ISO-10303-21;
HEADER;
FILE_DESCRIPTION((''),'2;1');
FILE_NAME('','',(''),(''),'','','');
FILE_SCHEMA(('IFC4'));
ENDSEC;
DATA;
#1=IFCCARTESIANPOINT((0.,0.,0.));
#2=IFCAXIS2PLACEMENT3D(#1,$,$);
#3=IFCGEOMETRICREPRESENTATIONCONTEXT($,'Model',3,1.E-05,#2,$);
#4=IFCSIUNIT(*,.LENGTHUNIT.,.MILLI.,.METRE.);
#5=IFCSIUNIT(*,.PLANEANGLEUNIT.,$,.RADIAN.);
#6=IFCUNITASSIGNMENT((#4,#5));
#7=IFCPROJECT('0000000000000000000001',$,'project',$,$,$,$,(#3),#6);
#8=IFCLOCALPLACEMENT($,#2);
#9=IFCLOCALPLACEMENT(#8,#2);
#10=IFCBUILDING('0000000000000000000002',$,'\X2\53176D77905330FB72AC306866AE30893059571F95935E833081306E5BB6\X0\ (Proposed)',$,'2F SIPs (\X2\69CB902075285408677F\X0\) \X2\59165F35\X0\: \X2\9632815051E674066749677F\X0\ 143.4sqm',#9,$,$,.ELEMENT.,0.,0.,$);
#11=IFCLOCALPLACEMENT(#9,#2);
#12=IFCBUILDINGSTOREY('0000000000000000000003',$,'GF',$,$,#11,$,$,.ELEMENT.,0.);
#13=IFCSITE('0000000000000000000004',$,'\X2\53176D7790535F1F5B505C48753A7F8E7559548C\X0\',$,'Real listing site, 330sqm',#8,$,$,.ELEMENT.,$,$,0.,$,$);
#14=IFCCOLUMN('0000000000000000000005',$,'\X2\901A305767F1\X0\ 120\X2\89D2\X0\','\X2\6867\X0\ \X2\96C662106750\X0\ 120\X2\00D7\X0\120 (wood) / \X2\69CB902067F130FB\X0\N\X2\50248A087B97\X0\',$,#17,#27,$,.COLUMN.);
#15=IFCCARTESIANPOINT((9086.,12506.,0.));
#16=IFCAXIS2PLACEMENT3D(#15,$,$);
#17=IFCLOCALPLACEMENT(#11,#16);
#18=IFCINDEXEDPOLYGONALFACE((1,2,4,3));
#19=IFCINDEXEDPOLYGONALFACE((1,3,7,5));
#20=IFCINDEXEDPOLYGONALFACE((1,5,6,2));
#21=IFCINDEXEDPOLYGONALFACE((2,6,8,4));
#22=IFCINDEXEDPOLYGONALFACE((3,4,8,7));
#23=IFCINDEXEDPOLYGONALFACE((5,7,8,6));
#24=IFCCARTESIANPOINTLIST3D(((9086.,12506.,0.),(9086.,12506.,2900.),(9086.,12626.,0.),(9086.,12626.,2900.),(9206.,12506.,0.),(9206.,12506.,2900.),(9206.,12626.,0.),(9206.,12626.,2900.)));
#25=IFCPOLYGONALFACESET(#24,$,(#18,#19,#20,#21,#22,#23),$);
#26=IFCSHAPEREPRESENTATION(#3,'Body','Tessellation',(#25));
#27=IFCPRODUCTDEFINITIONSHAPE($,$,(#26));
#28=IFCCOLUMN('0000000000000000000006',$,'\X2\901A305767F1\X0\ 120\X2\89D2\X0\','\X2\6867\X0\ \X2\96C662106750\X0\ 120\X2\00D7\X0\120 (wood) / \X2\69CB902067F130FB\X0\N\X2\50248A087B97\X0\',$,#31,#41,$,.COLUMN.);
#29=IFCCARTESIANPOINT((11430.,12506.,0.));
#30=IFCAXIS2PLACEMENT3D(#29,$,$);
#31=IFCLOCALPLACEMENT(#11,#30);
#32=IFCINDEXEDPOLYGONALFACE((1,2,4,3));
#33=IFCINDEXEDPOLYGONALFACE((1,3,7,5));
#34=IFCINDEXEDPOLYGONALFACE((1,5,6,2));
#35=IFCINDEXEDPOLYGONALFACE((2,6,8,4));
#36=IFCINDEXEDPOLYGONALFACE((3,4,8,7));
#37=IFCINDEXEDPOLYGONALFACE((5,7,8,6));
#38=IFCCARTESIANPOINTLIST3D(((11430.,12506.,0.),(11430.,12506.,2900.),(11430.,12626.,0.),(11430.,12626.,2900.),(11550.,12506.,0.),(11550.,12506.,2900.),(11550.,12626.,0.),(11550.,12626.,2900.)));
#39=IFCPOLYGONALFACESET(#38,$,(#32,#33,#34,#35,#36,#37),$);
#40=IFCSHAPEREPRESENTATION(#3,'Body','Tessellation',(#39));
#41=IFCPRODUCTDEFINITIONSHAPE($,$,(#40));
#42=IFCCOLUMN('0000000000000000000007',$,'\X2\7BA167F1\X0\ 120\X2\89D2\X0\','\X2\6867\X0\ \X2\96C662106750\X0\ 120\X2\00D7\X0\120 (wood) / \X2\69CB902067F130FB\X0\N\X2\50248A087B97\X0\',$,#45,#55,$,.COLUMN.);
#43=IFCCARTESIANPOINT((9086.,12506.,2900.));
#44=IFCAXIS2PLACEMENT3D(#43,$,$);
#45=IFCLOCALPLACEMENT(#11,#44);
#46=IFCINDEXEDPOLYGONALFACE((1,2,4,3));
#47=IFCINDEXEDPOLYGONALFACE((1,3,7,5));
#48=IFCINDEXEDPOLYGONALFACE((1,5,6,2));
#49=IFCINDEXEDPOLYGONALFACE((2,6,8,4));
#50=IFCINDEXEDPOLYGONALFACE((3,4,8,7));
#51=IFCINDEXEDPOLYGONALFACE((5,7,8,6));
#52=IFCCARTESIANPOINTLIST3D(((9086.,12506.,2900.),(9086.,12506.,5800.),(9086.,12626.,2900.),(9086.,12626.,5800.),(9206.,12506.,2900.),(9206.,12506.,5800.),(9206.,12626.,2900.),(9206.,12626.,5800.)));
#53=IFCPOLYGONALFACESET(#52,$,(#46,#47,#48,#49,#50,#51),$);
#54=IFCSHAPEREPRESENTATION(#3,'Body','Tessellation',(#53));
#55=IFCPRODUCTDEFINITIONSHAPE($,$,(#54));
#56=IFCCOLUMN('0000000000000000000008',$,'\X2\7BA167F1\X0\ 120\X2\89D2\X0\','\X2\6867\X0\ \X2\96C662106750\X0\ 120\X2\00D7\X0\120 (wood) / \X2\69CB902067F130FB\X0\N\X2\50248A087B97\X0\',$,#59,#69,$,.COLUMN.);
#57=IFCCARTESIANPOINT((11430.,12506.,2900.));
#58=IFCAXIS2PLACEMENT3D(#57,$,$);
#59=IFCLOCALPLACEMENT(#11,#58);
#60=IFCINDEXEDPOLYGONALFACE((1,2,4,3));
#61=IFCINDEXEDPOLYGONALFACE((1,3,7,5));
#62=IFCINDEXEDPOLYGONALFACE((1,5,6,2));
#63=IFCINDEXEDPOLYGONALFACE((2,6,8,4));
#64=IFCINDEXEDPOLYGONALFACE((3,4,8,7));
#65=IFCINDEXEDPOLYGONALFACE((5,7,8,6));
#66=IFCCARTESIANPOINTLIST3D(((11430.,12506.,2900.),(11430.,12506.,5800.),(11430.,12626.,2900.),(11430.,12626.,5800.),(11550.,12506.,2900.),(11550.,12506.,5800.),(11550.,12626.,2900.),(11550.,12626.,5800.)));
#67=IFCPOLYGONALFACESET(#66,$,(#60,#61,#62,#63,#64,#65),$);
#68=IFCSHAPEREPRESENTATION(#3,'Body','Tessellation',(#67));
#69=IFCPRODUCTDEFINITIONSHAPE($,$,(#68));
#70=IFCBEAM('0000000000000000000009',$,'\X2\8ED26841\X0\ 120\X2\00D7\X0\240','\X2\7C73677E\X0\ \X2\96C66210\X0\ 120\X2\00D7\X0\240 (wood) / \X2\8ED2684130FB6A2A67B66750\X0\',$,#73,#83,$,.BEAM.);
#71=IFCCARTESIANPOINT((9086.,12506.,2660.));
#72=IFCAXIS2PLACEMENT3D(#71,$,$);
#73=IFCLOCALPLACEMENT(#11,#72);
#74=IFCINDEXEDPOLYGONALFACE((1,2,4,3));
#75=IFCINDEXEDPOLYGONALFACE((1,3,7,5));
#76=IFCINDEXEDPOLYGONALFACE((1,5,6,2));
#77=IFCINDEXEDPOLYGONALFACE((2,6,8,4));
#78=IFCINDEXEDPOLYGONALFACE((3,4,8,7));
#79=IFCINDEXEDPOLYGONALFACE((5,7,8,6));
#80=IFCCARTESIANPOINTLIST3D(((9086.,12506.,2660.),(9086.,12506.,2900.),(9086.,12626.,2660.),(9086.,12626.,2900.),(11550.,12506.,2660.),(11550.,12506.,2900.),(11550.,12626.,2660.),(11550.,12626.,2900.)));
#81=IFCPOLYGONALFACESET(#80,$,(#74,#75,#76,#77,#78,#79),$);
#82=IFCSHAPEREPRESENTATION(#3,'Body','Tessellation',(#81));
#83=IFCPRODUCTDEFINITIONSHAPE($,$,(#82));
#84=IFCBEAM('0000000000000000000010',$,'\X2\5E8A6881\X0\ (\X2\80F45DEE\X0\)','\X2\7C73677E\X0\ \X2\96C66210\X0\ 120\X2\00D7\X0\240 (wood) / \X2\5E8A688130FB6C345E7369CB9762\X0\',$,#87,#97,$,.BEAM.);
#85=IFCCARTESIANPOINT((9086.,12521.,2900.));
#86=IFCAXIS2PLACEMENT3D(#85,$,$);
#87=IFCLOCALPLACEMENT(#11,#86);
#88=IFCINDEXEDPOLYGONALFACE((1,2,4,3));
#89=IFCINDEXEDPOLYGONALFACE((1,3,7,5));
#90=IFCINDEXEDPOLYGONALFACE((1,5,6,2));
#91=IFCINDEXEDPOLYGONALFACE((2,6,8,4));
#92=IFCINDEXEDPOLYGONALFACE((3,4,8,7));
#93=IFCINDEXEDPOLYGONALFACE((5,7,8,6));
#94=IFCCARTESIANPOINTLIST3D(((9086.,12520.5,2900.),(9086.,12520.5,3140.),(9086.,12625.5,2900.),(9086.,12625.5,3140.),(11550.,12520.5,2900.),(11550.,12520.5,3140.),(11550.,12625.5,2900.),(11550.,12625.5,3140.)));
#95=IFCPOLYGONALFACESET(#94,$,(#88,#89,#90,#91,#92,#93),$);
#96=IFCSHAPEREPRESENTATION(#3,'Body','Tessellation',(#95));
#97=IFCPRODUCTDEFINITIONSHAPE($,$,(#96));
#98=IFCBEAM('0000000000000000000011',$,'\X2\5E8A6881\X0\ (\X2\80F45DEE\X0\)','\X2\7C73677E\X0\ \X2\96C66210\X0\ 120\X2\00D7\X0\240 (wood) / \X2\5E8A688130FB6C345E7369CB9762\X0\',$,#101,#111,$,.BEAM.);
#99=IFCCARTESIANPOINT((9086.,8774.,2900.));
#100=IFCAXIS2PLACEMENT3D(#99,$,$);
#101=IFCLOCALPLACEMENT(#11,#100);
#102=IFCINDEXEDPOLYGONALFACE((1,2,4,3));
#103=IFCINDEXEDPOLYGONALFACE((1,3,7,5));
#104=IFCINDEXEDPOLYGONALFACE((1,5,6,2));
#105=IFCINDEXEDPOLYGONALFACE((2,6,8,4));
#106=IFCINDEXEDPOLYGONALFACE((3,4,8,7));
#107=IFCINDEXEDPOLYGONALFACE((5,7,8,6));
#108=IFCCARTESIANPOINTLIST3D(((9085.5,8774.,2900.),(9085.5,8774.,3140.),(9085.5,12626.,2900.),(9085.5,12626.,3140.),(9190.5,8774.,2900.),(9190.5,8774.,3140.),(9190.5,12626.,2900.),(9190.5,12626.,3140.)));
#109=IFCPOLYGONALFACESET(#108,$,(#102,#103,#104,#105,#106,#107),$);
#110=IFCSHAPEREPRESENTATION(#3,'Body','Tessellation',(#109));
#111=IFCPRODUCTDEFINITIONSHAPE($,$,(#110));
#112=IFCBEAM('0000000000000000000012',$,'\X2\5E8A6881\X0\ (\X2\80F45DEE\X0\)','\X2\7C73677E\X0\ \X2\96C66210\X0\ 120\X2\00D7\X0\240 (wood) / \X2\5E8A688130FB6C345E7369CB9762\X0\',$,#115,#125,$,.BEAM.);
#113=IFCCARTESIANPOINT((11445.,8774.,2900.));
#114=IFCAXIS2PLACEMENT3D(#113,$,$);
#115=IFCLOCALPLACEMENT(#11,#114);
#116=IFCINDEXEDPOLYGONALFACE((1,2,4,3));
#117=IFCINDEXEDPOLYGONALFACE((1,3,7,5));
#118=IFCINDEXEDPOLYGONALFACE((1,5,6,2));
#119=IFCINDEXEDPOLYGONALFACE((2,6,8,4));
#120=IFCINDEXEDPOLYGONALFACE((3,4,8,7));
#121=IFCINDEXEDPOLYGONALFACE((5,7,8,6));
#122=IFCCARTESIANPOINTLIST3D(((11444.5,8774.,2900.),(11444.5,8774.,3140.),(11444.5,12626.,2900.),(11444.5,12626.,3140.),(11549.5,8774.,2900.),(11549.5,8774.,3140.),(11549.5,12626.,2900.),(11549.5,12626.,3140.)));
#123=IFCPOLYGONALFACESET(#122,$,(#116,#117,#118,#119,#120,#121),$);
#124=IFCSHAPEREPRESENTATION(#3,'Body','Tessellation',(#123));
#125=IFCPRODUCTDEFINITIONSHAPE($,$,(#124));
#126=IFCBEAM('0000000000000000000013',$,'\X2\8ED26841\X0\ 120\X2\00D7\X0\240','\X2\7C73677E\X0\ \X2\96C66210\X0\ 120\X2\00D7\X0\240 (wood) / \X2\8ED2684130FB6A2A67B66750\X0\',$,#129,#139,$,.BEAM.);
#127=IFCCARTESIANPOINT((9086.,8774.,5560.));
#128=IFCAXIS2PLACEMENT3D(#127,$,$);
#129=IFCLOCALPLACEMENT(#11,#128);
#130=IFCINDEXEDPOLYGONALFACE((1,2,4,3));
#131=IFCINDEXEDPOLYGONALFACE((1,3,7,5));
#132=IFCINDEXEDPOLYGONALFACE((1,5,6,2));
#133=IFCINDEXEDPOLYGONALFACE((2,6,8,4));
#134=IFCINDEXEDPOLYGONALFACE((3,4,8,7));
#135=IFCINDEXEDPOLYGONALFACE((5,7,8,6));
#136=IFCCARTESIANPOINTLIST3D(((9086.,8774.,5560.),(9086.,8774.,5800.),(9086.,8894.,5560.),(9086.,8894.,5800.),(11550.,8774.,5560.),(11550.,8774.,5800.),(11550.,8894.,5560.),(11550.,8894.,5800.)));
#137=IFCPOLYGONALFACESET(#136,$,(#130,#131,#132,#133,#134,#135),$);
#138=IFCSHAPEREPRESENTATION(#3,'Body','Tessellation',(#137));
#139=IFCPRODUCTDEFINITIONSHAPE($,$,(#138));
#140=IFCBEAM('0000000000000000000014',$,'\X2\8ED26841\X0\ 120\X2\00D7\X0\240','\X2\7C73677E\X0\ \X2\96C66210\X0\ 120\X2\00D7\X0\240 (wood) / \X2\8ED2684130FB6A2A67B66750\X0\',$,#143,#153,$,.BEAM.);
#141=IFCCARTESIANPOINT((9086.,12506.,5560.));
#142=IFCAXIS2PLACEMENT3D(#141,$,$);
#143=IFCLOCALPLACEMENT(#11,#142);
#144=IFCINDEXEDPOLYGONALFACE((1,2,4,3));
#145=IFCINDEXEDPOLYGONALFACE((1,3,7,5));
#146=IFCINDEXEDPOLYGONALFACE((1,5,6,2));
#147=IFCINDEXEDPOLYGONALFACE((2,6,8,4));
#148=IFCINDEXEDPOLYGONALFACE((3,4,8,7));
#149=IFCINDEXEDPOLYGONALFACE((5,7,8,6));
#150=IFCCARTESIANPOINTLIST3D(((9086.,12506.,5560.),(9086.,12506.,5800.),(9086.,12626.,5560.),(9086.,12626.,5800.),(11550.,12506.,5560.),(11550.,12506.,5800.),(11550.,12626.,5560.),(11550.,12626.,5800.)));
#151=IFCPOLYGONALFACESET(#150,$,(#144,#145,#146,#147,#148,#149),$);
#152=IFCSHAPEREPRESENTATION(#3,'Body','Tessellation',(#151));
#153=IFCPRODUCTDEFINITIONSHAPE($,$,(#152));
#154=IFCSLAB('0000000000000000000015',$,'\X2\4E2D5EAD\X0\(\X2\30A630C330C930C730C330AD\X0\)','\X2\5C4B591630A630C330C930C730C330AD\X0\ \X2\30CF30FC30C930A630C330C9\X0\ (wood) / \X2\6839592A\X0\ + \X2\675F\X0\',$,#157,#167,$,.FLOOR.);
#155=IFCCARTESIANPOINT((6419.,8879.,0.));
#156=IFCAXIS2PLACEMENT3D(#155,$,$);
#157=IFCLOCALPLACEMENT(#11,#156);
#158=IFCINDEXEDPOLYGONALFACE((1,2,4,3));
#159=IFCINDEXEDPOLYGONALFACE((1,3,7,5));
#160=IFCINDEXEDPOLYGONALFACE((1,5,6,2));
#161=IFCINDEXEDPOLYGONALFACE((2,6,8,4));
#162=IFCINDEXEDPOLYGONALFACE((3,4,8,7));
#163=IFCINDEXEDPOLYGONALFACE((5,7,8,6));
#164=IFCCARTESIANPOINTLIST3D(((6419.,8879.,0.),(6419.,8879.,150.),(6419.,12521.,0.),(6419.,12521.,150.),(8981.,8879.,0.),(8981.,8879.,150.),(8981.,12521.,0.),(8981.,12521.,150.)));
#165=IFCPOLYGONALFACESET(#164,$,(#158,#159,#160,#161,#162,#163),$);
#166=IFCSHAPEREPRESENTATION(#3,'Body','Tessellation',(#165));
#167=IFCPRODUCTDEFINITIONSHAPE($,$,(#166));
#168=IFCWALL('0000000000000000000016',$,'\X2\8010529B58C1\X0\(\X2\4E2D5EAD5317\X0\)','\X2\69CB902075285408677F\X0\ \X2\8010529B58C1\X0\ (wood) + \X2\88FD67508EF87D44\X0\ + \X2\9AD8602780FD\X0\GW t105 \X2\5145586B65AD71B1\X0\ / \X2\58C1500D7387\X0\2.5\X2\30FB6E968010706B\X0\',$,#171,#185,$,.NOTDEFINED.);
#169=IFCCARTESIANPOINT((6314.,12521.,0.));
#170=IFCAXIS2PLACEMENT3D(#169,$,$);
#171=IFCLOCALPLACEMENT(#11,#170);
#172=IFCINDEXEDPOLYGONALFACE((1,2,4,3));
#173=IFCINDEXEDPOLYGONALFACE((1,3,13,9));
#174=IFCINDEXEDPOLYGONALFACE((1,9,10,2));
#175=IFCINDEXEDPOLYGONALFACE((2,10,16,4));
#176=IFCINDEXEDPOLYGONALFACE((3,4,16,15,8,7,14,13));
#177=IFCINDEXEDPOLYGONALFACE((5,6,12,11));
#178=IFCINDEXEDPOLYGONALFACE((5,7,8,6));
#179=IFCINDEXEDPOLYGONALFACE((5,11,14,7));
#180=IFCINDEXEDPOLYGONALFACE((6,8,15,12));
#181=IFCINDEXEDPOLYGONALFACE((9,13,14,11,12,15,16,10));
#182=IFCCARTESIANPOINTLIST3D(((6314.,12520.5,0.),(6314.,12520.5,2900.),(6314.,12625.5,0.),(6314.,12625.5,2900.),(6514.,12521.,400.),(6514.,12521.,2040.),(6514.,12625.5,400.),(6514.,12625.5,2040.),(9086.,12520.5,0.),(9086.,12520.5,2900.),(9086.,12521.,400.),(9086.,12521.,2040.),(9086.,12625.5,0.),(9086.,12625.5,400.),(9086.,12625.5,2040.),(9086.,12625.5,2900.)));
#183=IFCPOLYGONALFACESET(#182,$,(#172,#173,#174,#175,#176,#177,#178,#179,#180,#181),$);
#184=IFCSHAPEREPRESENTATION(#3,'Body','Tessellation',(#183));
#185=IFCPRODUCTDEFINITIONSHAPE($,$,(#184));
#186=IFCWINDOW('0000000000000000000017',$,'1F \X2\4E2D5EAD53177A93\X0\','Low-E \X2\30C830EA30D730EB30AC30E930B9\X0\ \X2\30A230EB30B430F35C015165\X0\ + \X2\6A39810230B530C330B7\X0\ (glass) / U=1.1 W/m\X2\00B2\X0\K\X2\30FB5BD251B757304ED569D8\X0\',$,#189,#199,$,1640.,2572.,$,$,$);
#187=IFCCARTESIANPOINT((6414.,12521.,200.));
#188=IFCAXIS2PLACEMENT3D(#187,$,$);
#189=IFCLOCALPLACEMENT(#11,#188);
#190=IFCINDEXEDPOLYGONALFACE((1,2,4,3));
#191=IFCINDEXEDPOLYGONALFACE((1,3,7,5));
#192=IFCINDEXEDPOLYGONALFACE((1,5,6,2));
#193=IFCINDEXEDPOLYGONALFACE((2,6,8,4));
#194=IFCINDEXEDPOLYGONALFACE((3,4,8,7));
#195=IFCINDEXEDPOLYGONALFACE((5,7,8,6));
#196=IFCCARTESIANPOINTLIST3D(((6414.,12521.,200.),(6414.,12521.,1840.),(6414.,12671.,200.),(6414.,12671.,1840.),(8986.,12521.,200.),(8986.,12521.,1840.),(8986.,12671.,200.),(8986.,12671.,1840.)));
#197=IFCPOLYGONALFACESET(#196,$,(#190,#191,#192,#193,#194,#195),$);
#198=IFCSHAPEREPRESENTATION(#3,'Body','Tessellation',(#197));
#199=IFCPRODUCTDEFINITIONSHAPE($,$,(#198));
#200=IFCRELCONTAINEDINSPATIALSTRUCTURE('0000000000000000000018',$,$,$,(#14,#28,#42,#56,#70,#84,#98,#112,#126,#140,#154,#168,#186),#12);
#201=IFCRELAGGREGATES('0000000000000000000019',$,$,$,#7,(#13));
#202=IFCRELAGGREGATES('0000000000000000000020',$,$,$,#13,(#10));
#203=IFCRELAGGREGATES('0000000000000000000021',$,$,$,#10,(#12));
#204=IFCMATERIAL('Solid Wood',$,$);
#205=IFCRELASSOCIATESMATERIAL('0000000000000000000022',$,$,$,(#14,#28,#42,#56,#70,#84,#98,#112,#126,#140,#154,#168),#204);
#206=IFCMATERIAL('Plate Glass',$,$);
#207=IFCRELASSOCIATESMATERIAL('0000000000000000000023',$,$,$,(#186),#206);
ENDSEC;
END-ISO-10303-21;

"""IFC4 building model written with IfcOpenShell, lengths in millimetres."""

from ifc_helpers import new_model, si_unit, frame, frame_2d, origin, place, context, project, spatial, rectangle, extrude, material, element, fill, save


model = new_model("IFC4")

# Units and contexts
model_context = context("Model", 3, precision=1e-05, world=origin())
ifc_project = project(units=[si_unit("LENGTHUNIT", "METRE", prefix="MILLI"), si_unit("PLANEANGLEUNIT", "RADIAN")], contexts=[model_context])

# Site, building, storey
site_placement = place(None, origin())
site = spatial("IfcSite", under=ifc_project, at=site_placement, Name="北海道弟子屈町美留和", ObjectType="Real listing site, 330sqm", CompositionType="ELEMENT", RefElevation=0.0)
building_placement = place(site_placement, origin())
building = spatial("IfcBuilding", under=site, at=building_placement, Name="北海道・犬と暮らす土間広めの家 (Proposed)", ObjectType="2F SIPs (構造用合板) 外張: 防腐処理杉板 143.4sqm", CompositionType="ELEMENT", ElevationOfRefHeight=0.0, ElevationOfTerrain=0.0)
storey_placement = place(building_placement, origin())
storey = spatial("IfcBuildingStorey", under=building, at=storey_placement, Name="GF", CompositionType="ELEMENT", Elevation=0.0)

# Columns
ifc_material_1 = material(Name="Solid Wood")
column_1_placement = place(storey_placement, frame((9086.0, 12506.0, 0.0)))
element("IfcColumn", 1, at=column_1_placement, inside=storey, material=ifc_material_1, Name="通し柱 120角", Description="桧 集成材 120×120 (wood) / 構造柱・N値計算", PredefinedType="COLUMN", context=model_context, shape_type="SweptSolid", body=[
    extrude(rectangle(XDim=120.0, YDim=120.0, at=frame_2d((60.0, 60.0))), frame((9086.0, 12506.0, 0.0)), (0.0, 0.0, 1.0), 2900.0),
])
column_2_placement = place(storey_placement, frame((11430.0, 12506.0, 0.0)))
element("IfcColumn", 2, at=column_2_placement, inside=storey, material=ifc_material_1, Name="通し柱 120角", Description="桧 集成材 120×120 (wood) / 構造柱・N値計算", PredefinedType="COLUMN", context=model_context, shape_type="SweptSolid", body=[
    extrude(rectangle(XDim=120.0, YDim=120.0, at=frame_2d((60.0, 60.0))), frame((11430.0, 12506.0, 0.0)), (0.0, 0.0, 1.0), 2900.0),
])
column_3_placement = place(storey_placement, frame((9086.0, 12506.0, 2900.0)))
element("IfcColumn", 3, at=column_3_placement, inside=storey, material=ifc_material_1, Name="管柱 120角", Description="桧 集成材 120×120 (wood) / 構造柱・N値計算", PredefinedType="COLUMN", context=model_context, shape_type="SweptSolid", body=[
    extrude(rectangle(XDim=120.0, YDim=120.0, at=frame_2d((60.0, 60.0))), frame((9086.0, 12506.0, 2900.0)), (0.0, 0.0, 1.0), 2900.0),
])
column_4_placement = place(storey_placement, frame((11430.0, 12506.0, 2900.0)))
element("IfcColumn", 4, at=column_4_placement, inside=storey, material=ifc_material_1, Name="管柱 120角", Description="桧 集成材 120×120 (wood) / 構造柱・N値計算", PredefinedType="COLUMN", context=model_context, shape_type="SweptSolid", body=[
    extrude(rectangle(XDim=120.0, YDim=120.0, at=frame_2d((60.0, 60.0))), frame((11430.0, 12506.0, 2900.0)), (0.0, 0.0, 1.0), 2900.0),
])

# Beams
beam_1_placement = place(storey_placement, frame((9086.0, 12506.0, 2660.0)))
element("IfcBeam", 5, at=beam_1_placement, inside=storey, material=ifc_material_1, Name="軒桁 120×240", Description="米松 集成 120×240 (wood) / 軒桁・横架材", PredefinedType="BEAM", context=model_context, shape_type="SweptSolid", body=[
    extrude(rectangle(XDim=2464.0, YDim=120.0, at=frame_2d((1232.0, 60.0))), frame((9086.0, 12506.0, 2660.0)), (0.0, 0.0, 1.0), 240.0),
])
beam_2_placement = place(storey_placement, frame((9086.0, 12521.0, 2900.0)))
element("IfcBeam", 6, at=beam_2_placement, inside=storey, material=ifc_material_1, Name="床梁 (胴差)", Description="米松 集成 120×240 (wood) / 床梁・水平構面", PredefinedType="BEAM", context=model_context, shape_type="SweptSolid", body=[
    extrude(rectangle(XDim=2464.0, YDim=105.0, at=frame_2d((1232.0, 52.0))), frame((9086.0, 12521.0, 2900.0)), (0.0, 0.0, 1.0), 240.0),
])
beam_3_placement = place(storey_placement, frame((9086.0, 8774.0, 2900.0)))
element("IfcBeam", 7, at=beam_3_placement, inside=storey, material=ifc_material_1, Name="床梁 (胴差)", Description="米松 集成 120×240 (wood) / 床梁・水平構面", PredefinedType="BEAM", context=model_context, shape_type="SweptSolid", body=[
    extrude(rectangle(XDim=105.0, YDim=3852.0, at=frame_2d((52.0, 1926.0))), frame((9086.0, 8774.0, 2900.0)), (0.0, 0.0, 1.0), 240.0),
])
beam_4_placement = place(storey_placement, frame((11445.0, 8774.0, 2900.0)))
element("IfcBeam", 8, at=beam_4_placement, inside=storey, material=ifc_material_1, Name="床梁 (胴差)", Description="米松 集成 120×240 (wood) / 床梁・水平構面", PredefinedType="BEAM", context=model_context, shape_type="SweptSolid", body=[
    extrude(rectangle(XDim=105.0, YDim=3852.0, at=frame_2d((52.0, 1926.0))), frame((11445.0, 8774.0, 2900.0)), (0.0, 0.0, 1.0), 240.0),
])
beam_5_placement = place(storey_placement, frame((9086.0, 8774.0, 5560.0)))
element("IfcBeam", 9, at=beam_5_placement, inside=storey, material=ifc_material_1, Name="軒桁 120×240", Description="米松 集成 120×240 (wood) / 軒桁・横架材", PredefinedType="BEAM", context=model_context, shape_type="SweptSolid", body=[
    extrude(rectangle(XDim=2464.0, YDim=120.0, at=frame_2d((1232.0, 60.0))), frame((9086.0, 8774.0, 5560.0)), (0.0, 0.0, 1.0), 240.0),
])
beam_6_placement = place(storey_placement, frame((9086.0, 12506.0, 5560.0)))
element("IfcBeam", 10, at=beam_6_placement, inside=storey, material=ifc_material_1, Name="軒桁 120×240", Description="米松 集成 120×240 (wood) / 軒桁・横架材", PredefinedType="BEAM", context=model_context, shape_type="SweptSolid", body=[
    extrude(rectangle(XDim=2464.0, YDim=120.0, at=frame_2d((1232.0, 60.0))), frame((9086.0, 12506.0, 5560.0)), (0.0, 0.0, 1.0), 240.0),
])

# Slab
slab_placement = place(storey_placement, frame((6419.0, 8879.0, 0.0)))
element("IfcSlab", 11, at=slab_placement, inside=storey, material=ifc_material_1, Name="中庭(ウッドデッキ)", Description="屋外ウッドデッキ ハードウッド (wood) / 根太 + 束", PredefinedType="FLOOR", context=model_context, shape_type="SweptSolid", body=[
    extrude(rectangle(XDim=2562.0, YDim=3642.0, at=frame_2d((1281.0, 1821.0))), frame((6419.0, 8879.0, 0.0)), (0.0, 0.0, 1.0), 150.0),
])

# Wall, opening, window
wall_1_placement = place(storey_placement, frame((6314.0, 12521.0, 0.0)))
wall_1 = element("IfcWall", 12, at=wall_1_placement, inside=storey, material=ifc_material_1, Name="耐力壁(中庭北)", Description="構造用合板 耐力壁 (wood) + 製材軸組 + 高性能GW t105 充填断熱 / 壁倍率2.5・準耐火", PredefinedType="NOTDEFINED", context=model_context, shape_type="SweptSolid", body=[
    extrude(rectangle(XDim=2772.0, YDim=105.0, at=frame_2d((1386.0, 52.0))), frame((6314.0, 12521.0, 0.0)), (0.0, 0.0, 1.0), 2900.0),
])
opening_1_placement = place(storey_placement, frame((6414.0, 12521.0, 200.0)))
opening_1 = element("IfcOpeningElement", 13, at=opening_1_placement, cuts=wall_1, PredefinedType="NOTDEFINED", context=model_context, shape_type="SweptSolid", body=[
    extrude(rectangle(XDim=2572.0, YDim=150.0, at=frame_2d((1286.0, 75.0))), frame((6414.0, 12521.0, 200.0)), (0.0, 0.0, 1.0), 1640.0),
])
ifc_material_2 = material(Name="Plate Glass")
window_1_placement = place(storey_placement, frame((6414.0, 12521.0, 200.0)))
window_1 = element("IfcWindow", 14, at=window_1_placement, inside=storey, material=ifc_material_2, Name="1F 中庭北窓", Description="Low-E トリプルガラス アルゴン封入 + 樹脂サッシ (glass) / U=1.1 W/m²K・寒冷地仕様", OverallHeight=1640.0, OverallWidth=2572.0, context=model_context, shape_type="SweptSolid", body=[
    extrude(rectangle(XDim=2572.0, YDim=150.0, at=frame_2d((1286.0, 75.0))), frame((6414.0, 12521.0, 200.0)), (0.0, 0.0, 1.0), 1640.0),
])
fill(opening_1, window_1)

save(model, "model.ifc")
